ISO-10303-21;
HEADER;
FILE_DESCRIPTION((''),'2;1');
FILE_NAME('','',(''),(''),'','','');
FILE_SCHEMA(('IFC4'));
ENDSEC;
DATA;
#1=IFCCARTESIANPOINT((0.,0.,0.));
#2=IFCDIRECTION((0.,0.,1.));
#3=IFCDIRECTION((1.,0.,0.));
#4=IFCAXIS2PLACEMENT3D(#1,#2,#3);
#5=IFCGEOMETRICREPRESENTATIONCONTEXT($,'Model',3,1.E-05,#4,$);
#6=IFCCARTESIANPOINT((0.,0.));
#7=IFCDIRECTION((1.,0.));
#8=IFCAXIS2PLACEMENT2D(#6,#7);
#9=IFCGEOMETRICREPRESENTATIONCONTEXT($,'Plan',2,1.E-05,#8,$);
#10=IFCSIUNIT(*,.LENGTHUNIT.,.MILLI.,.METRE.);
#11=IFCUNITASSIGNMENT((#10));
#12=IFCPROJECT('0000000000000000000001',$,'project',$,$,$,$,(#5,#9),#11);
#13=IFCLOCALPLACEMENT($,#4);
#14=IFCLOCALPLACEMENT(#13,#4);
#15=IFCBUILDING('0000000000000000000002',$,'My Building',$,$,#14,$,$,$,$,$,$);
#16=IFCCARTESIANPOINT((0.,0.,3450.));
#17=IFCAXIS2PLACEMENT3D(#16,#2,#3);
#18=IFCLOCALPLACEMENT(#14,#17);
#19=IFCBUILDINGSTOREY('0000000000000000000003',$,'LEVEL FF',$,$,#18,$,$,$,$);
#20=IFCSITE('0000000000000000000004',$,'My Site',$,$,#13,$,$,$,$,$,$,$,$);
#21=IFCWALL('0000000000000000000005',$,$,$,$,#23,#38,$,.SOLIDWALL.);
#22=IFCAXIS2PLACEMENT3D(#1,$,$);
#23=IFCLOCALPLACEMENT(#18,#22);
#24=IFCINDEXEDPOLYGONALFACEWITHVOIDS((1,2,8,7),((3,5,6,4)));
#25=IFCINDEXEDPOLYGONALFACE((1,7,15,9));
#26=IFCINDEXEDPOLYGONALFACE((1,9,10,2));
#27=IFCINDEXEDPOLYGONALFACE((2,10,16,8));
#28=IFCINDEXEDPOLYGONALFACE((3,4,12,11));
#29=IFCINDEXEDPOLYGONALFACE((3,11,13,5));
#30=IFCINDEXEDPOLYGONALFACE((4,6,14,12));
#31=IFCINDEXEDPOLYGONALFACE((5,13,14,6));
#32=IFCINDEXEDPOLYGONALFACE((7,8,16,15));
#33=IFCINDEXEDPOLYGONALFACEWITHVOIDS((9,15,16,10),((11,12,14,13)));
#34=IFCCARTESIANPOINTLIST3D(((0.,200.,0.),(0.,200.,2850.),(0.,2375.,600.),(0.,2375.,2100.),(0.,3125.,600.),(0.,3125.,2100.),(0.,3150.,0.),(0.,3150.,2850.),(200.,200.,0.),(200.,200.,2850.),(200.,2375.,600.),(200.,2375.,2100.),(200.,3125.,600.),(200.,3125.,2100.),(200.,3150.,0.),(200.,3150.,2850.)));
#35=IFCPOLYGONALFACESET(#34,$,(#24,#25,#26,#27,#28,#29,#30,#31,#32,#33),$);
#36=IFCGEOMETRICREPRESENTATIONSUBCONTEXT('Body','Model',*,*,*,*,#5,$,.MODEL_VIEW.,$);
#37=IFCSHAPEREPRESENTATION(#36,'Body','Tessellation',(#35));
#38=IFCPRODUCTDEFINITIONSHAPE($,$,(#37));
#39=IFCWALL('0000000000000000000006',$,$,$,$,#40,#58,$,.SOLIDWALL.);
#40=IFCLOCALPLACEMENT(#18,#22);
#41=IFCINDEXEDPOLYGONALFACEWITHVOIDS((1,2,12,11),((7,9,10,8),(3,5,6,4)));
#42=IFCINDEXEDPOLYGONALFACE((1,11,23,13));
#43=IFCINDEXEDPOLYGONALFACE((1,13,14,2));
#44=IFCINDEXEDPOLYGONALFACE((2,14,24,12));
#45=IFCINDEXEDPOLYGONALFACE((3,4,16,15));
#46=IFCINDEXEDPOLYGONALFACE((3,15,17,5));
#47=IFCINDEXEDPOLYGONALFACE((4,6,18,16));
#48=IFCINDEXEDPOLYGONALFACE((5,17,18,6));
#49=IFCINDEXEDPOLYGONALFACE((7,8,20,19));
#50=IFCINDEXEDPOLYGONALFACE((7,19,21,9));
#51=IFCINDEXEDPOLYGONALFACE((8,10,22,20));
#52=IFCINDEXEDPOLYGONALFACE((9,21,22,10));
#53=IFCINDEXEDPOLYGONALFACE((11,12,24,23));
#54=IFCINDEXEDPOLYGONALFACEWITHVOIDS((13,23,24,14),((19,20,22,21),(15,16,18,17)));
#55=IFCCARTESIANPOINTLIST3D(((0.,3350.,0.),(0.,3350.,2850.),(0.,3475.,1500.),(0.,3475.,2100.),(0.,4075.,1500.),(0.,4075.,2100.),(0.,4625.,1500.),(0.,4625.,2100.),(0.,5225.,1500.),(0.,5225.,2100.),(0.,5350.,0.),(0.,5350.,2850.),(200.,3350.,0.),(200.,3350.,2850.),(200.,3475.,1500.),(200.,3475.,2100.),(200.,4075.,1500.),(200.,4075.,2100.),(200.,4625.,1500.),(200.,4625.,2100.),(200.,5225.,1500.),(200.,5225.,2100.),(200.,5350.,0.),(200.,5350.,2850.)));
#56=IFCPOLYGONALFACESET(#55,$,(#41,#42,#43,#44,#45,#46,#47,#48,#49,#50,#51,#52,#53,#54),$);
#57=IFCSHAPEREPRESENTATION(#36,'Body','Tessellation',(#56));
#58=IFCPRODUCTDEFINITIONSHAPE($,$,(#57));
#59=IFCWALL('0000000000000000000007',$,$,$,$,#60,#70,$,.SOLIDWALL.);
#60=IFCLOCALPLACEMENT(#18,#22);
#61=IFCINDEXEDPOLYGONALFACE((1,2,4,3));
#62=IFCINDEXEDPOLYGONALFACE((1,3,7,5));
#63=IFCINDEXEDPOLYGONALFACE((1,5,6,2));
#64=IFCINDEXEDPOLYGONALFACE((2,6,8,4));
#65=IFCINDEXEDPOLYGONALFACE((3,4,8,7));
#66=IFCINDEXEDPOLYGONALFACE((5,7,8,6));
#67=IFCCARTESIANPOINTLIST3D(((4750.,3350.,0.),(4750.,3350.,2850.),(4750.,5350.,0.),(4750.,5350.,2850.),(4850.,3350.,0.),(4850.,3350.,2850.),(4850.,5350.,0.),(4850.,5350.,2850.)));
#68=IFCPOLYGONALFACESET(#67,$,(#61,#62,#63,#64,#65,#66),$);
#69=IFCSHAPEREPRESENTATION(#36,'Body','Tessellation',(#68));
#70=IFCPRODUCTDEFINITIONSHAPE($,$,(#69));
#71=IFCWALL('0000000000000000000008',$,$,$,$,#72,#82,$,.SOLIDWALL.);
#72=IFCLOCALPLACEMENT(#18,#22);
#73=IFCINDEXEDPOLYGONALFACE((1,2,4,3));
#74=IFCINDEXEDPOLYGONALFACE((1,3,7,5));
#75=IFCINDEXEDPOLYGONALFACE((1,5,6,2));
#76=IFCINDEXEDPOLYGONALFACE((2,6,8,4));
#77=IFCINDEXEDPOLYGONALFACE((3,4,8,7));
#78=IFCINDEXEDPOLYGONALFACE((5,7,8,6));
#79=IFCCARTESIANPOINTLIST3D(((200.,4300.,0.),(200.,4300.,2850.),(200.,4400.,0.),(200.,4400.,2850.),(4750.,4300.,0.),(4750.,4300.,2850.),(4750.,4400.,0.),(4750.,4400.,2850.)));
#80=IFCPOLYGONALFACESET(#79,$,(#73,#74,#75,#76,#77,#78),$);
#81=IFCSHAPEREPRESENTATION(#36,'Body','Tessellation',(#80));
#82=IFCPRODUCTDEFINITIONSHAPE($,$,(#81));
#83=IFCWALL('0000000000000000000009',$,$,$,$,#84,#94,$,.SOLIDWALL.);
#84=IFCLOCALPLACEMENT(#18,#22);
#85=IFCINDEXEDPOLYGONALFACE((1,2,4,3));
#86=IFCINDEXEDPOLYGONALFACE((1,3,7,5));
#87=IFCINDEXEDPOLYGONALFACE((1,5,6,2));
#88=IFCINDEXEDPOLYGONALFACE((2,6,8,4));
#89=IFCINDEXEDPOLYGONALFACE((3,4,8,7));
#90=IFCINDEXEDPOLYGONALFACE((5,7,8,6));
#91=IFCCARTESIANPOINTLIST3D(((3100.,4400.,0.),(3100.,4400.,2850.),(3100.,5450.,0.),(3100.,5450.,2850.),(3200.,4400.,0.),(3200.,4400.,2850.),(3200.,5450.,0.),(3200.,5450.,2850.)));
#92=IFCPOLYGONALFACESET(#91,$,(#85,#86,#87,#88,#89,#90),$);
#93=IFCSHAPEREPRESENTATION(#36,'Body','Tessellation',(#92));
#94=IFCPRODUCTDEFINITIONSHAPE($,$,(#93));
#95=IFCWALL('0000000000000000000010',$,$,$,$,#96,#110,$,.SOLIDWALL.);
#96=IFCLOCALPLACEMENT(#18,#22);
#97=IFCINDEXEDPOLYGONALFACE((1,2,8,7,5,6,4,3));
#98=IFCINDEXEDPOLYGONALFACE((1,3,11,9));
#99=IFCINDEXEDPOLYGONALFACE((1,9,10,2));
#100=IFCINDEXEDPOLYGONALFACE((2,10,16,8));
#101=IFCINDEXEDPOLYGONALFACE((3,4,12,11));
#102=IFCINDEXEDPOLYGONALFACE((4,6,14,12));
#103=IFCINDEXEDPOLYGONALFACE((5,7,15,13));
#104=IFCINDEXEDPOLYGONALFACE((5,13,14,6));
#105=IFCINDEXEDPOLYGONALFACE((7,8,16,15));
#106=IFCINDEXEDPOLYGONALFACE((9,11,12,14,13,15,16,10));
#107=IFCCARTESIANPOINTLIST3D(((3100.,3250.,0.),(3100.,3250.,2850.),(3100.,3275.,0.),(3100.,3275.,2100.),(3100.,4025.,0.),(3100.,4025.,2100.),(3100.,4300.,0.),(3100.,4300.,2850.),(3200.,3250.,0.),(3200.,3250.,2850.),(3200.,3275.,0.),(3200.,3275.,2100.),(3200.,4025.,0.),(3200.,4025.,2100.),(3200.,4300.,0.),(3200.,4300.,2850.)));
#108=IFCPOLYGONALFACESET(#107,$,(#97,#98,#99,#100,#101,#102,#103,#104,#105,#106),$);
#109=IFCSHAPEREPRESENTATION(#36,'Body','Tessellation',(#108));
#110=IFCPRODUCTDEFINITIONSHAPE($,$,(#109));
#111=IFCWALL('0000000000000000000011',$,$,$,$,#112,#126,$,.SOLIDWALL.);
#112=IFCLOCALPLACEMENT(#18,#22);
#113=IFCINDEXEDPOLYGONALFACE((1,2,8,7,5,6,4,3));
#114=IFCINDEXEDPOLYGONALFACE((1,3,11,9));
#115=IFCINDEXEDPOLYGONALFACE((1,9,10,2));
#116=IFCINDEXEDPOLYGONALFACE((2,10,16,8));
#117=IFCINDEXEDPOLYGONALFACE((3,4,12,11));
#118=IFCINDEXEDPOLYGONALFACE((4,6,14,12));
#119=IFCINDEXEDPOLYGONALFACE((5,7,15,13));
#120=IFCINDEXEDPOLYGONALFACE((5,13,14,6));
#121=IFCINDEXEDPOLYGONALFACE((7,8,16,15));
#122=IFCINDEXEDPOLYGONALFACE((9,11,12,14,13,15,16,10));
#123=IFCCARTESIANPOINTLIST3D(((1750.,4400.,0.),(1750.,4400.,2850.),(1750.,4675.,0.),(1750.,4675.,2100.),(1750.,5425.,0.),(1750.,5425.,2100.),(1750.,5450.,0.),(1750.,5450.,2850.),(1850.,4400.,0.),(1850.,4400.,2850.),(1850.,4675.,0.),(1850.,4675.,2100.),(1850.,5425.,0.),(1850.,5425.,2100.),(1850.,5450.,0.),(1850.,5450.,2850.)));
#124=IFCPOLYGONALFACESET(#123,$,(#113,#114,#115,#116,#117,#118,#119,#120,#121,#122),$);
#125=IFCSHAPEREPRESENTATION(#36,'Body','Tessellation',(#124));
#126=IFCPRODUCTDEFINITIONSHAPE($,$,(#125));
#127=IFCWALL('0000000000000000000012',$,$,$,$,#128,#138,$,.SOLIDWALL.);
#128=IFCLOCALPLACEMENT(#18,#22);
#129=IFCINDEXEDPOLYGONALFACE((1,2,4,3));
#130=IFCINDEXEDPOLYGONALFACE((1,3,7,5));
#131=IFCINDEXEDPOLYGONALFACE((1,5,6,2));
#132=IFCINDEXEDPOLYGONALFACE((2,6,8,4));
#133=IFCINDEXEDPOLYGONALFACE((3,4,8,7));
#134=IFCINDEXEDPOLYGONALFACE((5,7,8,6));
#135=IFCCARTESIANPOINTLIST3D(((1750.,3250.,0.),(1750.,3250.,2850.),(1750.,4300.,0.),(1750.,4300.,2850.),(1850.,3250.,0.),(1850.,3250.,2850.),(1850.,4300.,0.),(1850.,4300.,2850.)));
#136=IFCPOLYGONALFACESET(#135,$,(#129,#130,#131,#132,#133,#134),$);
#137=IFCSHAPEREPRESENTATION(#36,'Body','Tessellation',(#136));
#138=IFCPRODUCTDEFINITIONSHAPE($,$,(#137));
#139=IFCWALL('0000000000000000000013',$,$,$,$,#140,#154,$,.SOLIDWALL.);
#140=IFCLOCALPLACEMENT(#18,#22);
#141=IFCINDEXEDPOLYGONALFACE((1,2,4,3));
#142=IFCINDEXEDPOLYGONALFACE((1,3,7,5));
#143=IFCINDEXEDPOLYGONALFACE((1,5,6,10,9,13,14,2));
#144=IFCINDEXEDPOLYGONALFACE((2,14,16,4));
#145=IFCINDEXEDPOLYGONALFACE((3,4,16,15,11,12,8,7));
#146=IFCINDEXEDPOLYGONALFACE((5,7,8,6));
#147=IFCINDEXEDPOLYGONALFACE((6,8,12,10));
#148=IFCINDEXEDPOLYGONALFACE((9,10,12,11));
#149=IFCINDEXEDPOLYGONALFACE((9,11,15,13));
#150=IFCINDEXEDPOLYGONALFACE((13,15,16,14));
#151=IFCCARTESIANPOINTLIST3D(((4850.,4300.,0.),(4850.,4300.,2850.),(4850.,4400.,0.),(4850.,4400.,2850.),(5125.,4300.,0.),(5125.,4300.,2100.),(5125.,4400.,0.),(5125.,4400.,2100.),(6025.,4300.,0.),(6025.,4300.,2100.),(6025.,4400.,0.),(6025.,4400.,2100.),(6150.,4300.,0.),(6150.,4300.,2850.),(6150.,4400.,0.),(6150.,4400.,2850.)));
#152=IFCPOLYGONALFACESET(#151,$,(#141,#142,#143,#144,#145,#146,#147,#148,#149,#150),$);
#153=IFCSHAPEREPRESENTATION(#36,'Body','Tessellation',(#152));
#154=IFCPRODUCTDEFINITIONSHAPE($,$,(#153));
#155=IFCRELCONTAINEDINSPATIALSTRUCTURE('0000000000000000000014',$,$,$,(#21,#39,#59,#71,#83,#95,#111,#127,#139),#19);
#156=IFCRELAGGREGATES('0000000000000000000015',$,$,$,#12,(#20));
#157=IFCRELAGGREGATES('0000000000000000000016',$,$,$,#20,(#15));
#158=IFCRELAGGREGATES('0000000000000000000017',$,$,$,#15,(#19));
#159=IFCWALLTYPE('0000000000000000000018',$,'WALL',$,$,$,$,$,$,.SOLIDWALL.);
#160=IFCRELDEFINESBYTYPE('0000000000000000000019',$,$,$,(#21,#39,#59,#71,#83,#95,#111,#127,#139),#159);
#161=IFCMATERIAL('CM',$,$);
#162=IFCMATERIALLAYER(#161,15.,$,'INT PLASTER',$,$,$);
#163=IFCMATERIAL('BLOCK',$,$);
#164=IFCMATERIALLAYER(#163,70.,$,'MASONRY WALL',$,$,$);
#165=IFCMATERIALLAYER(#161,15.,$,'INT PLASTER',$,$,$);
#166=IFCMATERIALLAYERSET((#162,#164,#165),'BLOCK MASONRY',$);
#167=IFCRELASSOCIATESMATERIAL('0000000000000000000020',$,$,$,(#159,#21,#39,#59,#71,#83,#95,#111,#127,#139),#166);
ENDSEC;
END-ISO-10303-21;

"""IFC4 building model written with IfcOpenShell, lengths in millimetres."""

from ifc_helpers import new_model, si_unit, frame, origin_with_axes, origin_2d_with_axis, place, context, subcontext, project, spatial, indexed_curve, outline, extrude, material, layer, layer_set, layer_usage, type_object, element, save


model = new_model("IFC4")

# Units and contexts
model_context = context("Model", 3, precision=1e-05, world=origin_with_axes())
plan_context = context("Plan", 2, precision=1e-05, world=origin_2d_with_axis())
body_context = subcontext(model_context, "Body", "Model", "MODEL_VIEW")
ifc_project = project(units=[si_unit("LENGTHUNIT", "METRE", prefix="MILLI")], contexts=[model_context, plan_context])

# Site, building, storey
site_placement = place(None, origin_with_axes())
site = spatial("IfcSite", under=ifc_project, at=site_placement, Name="My Site")
building_placement = place(site_placement, origin_with_axes())
building = spatial("IfcBuilding", under=site, at=building_placement, Name="My Building")
storey_placement = place(building_placement, frame((0.0, 0.0, 3450.0), z_axis=(0.0, 0.0, 1.0), x_axis=(1.0, 0.0, 0.0)))
storey = spatial("IfcBuildingStorey", under=building, at=storey_placement, Name="LEVEL FF")

# Shared definitions
ifc_material_1 = material(Name="CM")
ifc_layer_1 = layer(ifc_material_1, 15.0, Name="INT PLASTER")
ifc_material_2 = material(Name="BLOCK")
ifc_layer_2 = layer(ifc_material_2, 70.0, Name="MASONRY WALL")
ifc_layer_3 = layer(ifc_material_1, 15.0, Name="INT PLASTER")
ifc_layer_set_1 = layer_set([ifc_layer_1, ifc_layer_2, ifc_layer_3], Name="BLOCK MASONRY")
wall_type = type_object("IfcWallType", Name="WALL", PredefinedType="SOLIDWALL", material=ifc_layer_set_1)

# Wall, opening
ifc_layer_usage_1 = layer_usage(ifc_layer_set_1, "AXIS2", "POSITIVE", 0.0)
wall_1_placement = place(storey_placement, frame((200.0, 200.0, 0.0), z_axis=(0.0, 0.0, 1.0), x_axis=(0.0, 1.0, 0.0)))
wall_1 = element("IfcWall", 1, at=wall_1_placement, inside=storey, type_object=wall_type, material=ifc_layer_usage_1, PredefinedType="SOLIDWALL", context=body_context, shape_type="SweptSolid", body=[
    extrude(outline(indexed_curve([(0.0, 0.0), (0.0, 200.0), (2950.0, 200.0), (2950.0, 0.0), (0.0, 0.0)], self_intersect=False)), origin_with_axes(), (0.0, 0.0, 1.0), 2850.0),
])
opening_1_placement = place(wall_1_placement, frame((2175.0, 0.0, 600.0), z_axis=(0.0, 0.0, 1.0), x_axis=(1.0, 0.0, 0.0)))
element("IfcOpeningElement", 2, at=opening_1_placement, cuts=wall_1, PredefinedType="OPENING", context=body_context, shape_type="SweptSolid", body=[
    extrude(outline(indexed_curve([(0.0, 0.0), (0.0, 400.0), (750.0, 400.0), (750.0, 0.0), (0.0, 0.0)], self_intersect=False)), frame((0.0, -100.0, 0.0), z_axis=(0.0, 0.0, 1.0), x_axis=(1.0, 0.0, 0.0)), (0.0, 0.0, 1.0), 1500.0),
])

# Wall, openings
ifc_layer_usage_2 = layer_usage(ifc_layer_set_1, "AXIS2", "POSITIVE", 0.0)
wall_2_placement = place(storey_placement, frame((200.0, 3350.0, 0.0), z_axis=(0.0, 0.0, 1.0), x_axis=(0.0, 1.0, 0.0)))
wall_2 = element("IfcWall", 3, at=wall_2_placement, inside=storey, type_object=wall_type, material=ifc_layer_usage_2, PredefinedType="SOLIDWALL", context=body_context, shape_type="SweptSolid", body=[
    extrude(outline(indexed_curve([(0.0, 0.0), (0.0, 200.0), (2000.0, 200.0), (2000.0, 0.0), (0.0, 0.0)], self_intersect=False)), origin_with_axes(), (0.0, 0.0, 1.0), 2850.0),
])
opening_2_placement = place(wall_2_placement, frame((1275.0, 0.0, 1500.0), z_axis=(0.0, 0.0, 1.0), x_axis=(1.0, 0.0, 0.0)))
element("IfcOpeningElement", 4, at=opening_2_placement, cuts=wall_2, PredefinedType="OPENING", context=body_context, shape_type="SweptSolid", body=[
    extrude(outline(indexed_curve([(0.0, 0.0), (0.0, 400.0), (600.0, 400.0), (600.0, 0.0), (0.0, 0.0)], self_intersect=False)), frame((0.0, -100.0, 0.0), z_axis=(0.0, 0.0, 1.0), x_axis=(1.0, 0.0, 0.0)), (0.0, 0.0, 1.0), 600.0),
])
opening_3_placement = place(wall_2_placement, frame((125.0, 0.0, 1500.0), z_axis=(0.0, 0.0, 1.0), x_axis=(1.0, 0.0, 0.0)))
element("IfcOpeningElement", 5, at=opening_3_placement, cuts=wall_2, PredefinedType="OPENING", context=body_context, shape_type="SweptSolid", body=[
    extrude(outline(indexed_curve([(0.0, 0.0), (0.0, 400.0), (600.0, 400.0), (600.0, 0.0), (0.0, 0.0)], self_intersect=False)), frame((0.0, -100.0, 0.0), z_axis=(0.0, 0.0, 1.0), x_axis=(1.0, 0.0, 0.0)), (0.0, 0.0, 1.0), 600.0),
])

# Walls
ifc_layer_usage_3 = layer_usage(ifc_layer_set_1, "AXIS2", "POSITIVE", 0.0)
wall_3_placement = place(storey_placement, frame((4850.0, 3350.0, 0.0), z_axis=(0.0, 0.0, 1.0), x_axis=(0.0, 1.0, 0.0)))
element("IfcWall", 6, at=wall_3_placement, inside=storey, type_object=wall_type, material=ifc_layer_usage_3, PredefinedType="SOLIDWALL", context=body_context, shape_type="SweptSolid", body=[
    extrude(outline(indexed_curve([(0.0, 0.0), (0.0, 100.0), (2000.0, 100.0), (2000.0, 0.0), (0.0, 0.0)], self_intersect=False)), origin_with_axes(), (0.0, 0.0, 1.0), 2850.0),
])
ifc_layer_usage_4 = layer_usage(ifc_layer_set_1, "AXIS2", "POSITIVE", 0.0)
wall_4_placement = place(storey_placement, frame((200.0, 4400.0, 0.0), z_axis=(0.0, 0.0, 1.0), x_axis=(0.0, -1.0, 0.0)))
element("IfcWall", 7, at=wall_4_placement, inside=storey, type_object=wall_type, material=ifc_layer_usage_4, PredefinedType="SOLIDWALL", context=body_context, shape_type="SweptSolid", body=[
    extrude(outline(indexed_curve([(0.0, 0.0), (0.0, 4550.0), (100.0, 4550.0), (100.0, 0.0), (0.0, 0.0)], self_intersect=False)), origin_with_axes(), (0.0, 0.0, 1.0), 2850.0),
])
ifc_layer_usage_5 = layer_usage(ifc_layer_set_1, "AXIS2", "POSITIVE", 0.0)
wall_5_placement = place(storey_placement, frame((3200.0, 4400.0, 0.0), z_axis=(0.0, 0.0, 1.0), x_axis=(0.0, 1.0, 0.0)))
element("IfcWall", 8, at=wall_5_placement, inside=storey, type_object=wall_type, material=ifc_layer_usage_5, PredefinedType="SOLIDWALL", context=body_context, shape_type="SweptSolid", body=[
    extrude(outline(indexed_curve([(0.0, 0.0), (0.0, 100.0), (1050.0, 100.0), (1050.0, 0.0), (0.0, 0.0)], self_intersect=False)), origin_with_axes(), (0.0, 0.0, 1.0), 2850.0),
])

# Walls, openings
ifc_layer_usage_6 = layer_usage(ifc_layer_set_1, "AXIS2", "POSITIVE", 0.0)
wall_6_placement = place(storey_placement, frame((3200.0, 3250.0, 0.0), z_axis=(0.0, 0.0, 1.0), x_axis=(0.0, 1.0, 0.0)))
wall_6 = element("IfcWall", 9, at=wall_6_placement, inside=storey, type_object=wall_type, material=ifc_layer_usage_6, PredefinedType="SOLIDWALL", context=body_context, shape_type="SweptSolid", body=[
    extrude(outline(indexed_curve([(0.0, 0.0), (0.0, 100.0), (1050.0, 100.0), (1050.0, 0.0), (0.0, 0.0)], self_intersect=False)), origin_with_axes(), (0.0, 0.0, 1.0), 2850.0),
])
opening_4_placement = place(wall_6_placement, frame((775.0, 100.0, 0.0), z_axis=(0.0, 0.0, 1.0), x_axis=(-1.0, 0.0, 0.0)))
element("IfcOpeningElement", 10, at=opening_4_placement, cuts=wall_6, PredefinedType="OPENING", context=body_context, shape_type="SweptSolid", body=[
    extrude(outline(indexed_curve([(0.0, 0.0), (0.0, 400.0), (750.0, 400.0), (750.0, 0.0), (0.0, 0.0)], self_intersect=False)), frame((0.0, -100.0, 0.0), z_axis=(0.0, 0.0, 1.0), x_axis=(1.0, 0.0, 0.0)), (0.0, 0.0, 1.0), 2100.0),
])
ifc_layer_usage_7 = layer_usage(ifc_layer_set_1, "AXIS2", "POSITIVE", 0.0)
wall_7_placement = place(storey_placement, frame((1850.0, 4400.0, 0.0), z_axis=(0.0, 0.0, 1.0), x_axis=(0.0, 1.0, 0.0)))
wall_7 = element("IfcWall", 11, at=wall_7_placement, inside=storey, type_object=wall_type, material=ifc_layer_usage_7, PredefinedType="SOLIDWALL", context=body_context, shape_type="SweptSolid", body=[
    extrude(outline(indexed_curve([(0.0, 0.0), (0.0, 100.0), (1050.0, 100.0), (1050.0, 0.0), (0.0, 0.0)], self_intersect=False)), origin_with_axes(), (0.0, 0.0, 1.0), 2850.0),
])
opening_5_placement = place(wall_7_placement, frame((275.0, 0.0, 0.0), z_axis=(0.0, 0.0, 1.0), x_axis=(1.0, 0.0, 0.0)))
element("IfcOpeningElement", 12, at=opening_5_placement, cuts=wall_7, PredefinedType="OPENING", context=body_context, shape_type="SweptSolid", body=[
    extrude(outline(indexed_curve([(0.0, 0.0), (0.0, 400.0), (750.0, 400.0), (750.0, 0.0), (0.0, 0.0)], self_intersect=False)), frame((0.0, -100.0, 0.0), z_axis=(0.0, 0.0, 1.0), x_axis=(1.0, 0.0, 0.0)), (0.0, 0.0, 1.0), 2100.0),
])

# Wall
ifc_layer_usage_8 = layer_usage(ifc_layer_set_1, "AXIS2", "POSITIVE", 0.0)
wall_8_placement = place(storey_placement, frame((1850.0, 3250.0, 0.0), z_axis=(0.0, 0.0, 1.0), x_axis=(0.0, 1.0, 0.0)))
element("IfcWall", 13, at=wall_8_placement, inside=storey, type_object=wall_type, material=ifc_layer_usage_8, PredefinedType="SOLIDWALL", context=body_context, shape_type="SweptSolid", body=[
    extrude(outline(indexed_curve([(0.0, 0.0), (0.0, 100.0), (1050.0, 100.0), (1050.0, 0.0), (0.0, 0.0)], self_intersect=False)), origin_with_axes(), (0.0, 0.0, 1.0), 2850.0),
])

# Wall, opening
ifc_layer_usage_9 = layer_usage(ifc_layer_set_1, "AXIS2", "POSITIVE", 0.0)
wall_9_placement = place(storey_placement, frame((4850.0, 4400.0, 0.0), z_axis=(0.0, 0.0, 1.0), x_axis=(0.0, -1.0, 0.0)))
wall_9 = element("IfcWall", 14, at=wall_9_placement, inside=storey, type_object=wall_type, material=ifc_layer_usage_9, PredefinedType="SOLIDWALL", context=body_context, shape_type="SweptSolid", body=[
    extrude(outline(indexed_curve([(0.0, 0.0), (0.0, 1300.0), (100.0, 1300.0), (100.0, 0.0), (0.0, 0.0)], self_intersect=False)), origin_with_axes(), (0.0, 0.0, 1.0), 2850.0),
])
opening_6_placement = place(wall_9_placement, frame((0.0, 1175.0, 0.0), z_axis=(0.0, 0.0, 1.0), x_axis=(0.0, -1.0, 0.0)))
element("IfcOpeningElement", 15, at=opening_6_placement, cuts=wall_9, PredefinedType="OPENING", context=body_context, shape_type="SweptSolid", body=[
    extrude(outline(indexed_curve([(0.0, 0.0), (0.0, 400.0), (900.0, 400.0), (900.0, 0.0), (0.0, 0.0)], self_intersect=False)), frame((0.0, -100.0, 0.0), z_axis=(0.0, 0.0, 1.0), x_axis=(1.0, 0.0, 0.0)), (0.0, 0.0, 1.0), 2100.0),
])

save(model, "model.ifc")
